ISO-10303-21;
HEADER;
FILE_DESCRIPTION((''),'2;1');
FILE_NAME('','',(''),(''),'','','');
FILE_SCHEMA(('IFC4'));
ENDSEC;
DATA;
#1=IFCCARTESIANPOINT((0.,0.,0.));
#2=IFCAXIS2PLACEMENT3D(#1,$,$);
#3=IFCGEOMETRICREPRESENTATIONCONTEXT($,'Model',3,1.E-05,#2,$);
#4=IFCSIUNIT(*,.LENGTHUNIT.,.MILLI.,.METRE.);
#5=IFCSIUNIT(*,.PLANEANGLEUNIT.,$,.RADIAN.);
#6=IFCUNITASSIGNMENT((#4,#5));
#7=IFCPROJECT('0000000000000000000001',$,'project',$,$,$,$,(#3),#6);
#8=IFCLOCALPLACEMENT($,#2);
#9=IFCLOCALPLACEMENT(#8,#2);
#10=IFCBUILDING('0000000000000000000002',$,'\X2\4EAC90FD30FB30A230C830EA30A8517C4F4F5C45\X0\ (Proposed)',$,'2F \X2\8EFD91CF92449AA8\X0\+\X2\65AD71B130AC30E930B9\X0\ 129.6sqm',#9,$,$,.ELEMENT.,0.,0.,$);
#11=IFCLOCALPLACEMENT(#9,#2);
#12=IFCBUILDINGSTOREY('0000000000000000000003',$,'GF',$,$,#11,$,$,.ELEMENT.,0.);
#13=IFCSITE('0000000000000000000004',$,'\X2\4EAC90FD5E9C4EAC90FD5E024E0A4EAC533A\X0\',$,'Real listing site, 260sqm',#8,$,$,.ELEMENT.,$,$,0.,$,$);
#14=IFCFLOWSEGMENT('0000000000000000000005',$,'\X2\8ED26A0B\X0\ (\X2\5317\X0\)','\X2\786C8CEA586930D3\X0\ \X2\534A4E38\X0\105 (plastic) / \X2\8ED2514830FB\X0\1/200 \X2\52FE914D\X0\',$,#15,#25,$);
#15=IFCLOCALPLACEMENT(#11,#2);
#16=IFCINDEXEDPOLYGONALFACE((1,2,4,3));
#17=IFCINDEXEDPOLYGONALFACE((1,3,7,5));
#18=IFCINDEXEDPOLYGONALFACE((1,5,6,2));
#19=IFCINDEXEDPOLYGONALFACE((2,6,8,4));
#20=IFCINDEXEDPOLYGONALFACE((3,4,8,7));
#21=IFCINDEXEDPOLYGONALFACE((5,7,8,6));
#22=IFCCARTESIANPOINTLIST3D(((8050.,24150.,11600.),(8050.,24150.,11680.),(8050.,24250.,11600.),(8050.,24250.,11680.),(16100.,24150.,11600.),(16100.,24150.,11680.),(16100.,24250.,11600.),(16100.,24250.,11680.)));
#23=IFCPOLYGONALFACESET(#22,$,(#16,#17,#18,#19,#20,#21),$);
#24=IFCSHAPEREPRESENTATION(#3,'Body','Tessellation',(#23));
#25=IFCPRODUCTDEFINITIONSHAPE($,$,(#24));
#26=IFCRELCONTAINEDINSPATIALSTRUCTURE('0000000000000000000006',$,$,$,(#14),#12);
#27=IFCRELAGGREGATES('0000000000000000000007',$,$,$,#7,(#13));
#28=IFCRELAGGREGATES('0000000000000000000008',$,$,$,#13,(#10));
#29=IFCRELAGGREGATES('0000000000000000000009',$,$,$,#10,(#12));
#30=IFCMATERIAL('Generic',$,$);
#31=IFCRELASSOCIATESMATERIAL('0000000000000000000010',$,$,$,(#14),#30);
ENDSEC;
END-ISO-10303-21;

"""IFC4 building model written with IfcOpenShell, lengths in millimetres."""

from ifc_helpers import new_model, si_unit, frame, frame_2d, origin, place, context, project, spatial, rectangle, extrude, material, element, save


model = new_model("IFC4")

# Units and contexts
model_context = context("Model", 3, precision=1e-05, world=origin())
ifc_project = project(units=[si_unit("LENGTHUNIT", "METRE", prefix="MILLI"), si_unit("PLANEANGLEUNIT", "RADIAN")], contexts=[model_context])

# Site, building, storey
site_placement = place(None, origin())
site = spatial("IfcSite", under=ifc_project, at=site_placement, Name="京都府京都市上京区", ObjectType="Real listing site, 260sqm", CompositionType="ELEMENT", RefElevation=0.0)
building_placement = place(site_placement, origin())
building = spatial("IfcBuilding", under=site, at=building_placement, Name="京都・アトリエ兼住居 (Proposed)", ObjectType="2F 軽量鉄骨+断熱ガラス 129.6sqm", CompositionType="ELEMENT", ElevationOfRefHeight=0.0, ElevationOfTerrain=0.0)
storey_placement = place(building_placement, origin())
storey = spatial("IfcBuildingStorey", under=building, at=storey_placement, Name="GF", CompositionType="ELEMENT", Elevation=0.0)

# Shared definitions
ifc_material_1 = material(Name="Generic")

# Flow segment
flow_segment_1_placement = place(storey_placement, frame((4025.0, 12075.0, 5800.0)))
element("IfcFlowSegment", 1, at=flow_segment_1_placement, inside=storey, material=ifc_material_1, Name="軒樋 (北)", Description="硬質塩ビ 半丸105 (plastic) / 軒先・1/200 勾配", context=model_context, shape_type="SweptSolid", body=[
    extrude(rectangle(XDim=8050.0, YDim=100.0, at=frame_2d((4025.0, 50.0))), frame((4025.0, 12075.0, 5800.0)), (0.0, 0.0, 1.0), 80.0),
])

save(model, "model.ifc")
